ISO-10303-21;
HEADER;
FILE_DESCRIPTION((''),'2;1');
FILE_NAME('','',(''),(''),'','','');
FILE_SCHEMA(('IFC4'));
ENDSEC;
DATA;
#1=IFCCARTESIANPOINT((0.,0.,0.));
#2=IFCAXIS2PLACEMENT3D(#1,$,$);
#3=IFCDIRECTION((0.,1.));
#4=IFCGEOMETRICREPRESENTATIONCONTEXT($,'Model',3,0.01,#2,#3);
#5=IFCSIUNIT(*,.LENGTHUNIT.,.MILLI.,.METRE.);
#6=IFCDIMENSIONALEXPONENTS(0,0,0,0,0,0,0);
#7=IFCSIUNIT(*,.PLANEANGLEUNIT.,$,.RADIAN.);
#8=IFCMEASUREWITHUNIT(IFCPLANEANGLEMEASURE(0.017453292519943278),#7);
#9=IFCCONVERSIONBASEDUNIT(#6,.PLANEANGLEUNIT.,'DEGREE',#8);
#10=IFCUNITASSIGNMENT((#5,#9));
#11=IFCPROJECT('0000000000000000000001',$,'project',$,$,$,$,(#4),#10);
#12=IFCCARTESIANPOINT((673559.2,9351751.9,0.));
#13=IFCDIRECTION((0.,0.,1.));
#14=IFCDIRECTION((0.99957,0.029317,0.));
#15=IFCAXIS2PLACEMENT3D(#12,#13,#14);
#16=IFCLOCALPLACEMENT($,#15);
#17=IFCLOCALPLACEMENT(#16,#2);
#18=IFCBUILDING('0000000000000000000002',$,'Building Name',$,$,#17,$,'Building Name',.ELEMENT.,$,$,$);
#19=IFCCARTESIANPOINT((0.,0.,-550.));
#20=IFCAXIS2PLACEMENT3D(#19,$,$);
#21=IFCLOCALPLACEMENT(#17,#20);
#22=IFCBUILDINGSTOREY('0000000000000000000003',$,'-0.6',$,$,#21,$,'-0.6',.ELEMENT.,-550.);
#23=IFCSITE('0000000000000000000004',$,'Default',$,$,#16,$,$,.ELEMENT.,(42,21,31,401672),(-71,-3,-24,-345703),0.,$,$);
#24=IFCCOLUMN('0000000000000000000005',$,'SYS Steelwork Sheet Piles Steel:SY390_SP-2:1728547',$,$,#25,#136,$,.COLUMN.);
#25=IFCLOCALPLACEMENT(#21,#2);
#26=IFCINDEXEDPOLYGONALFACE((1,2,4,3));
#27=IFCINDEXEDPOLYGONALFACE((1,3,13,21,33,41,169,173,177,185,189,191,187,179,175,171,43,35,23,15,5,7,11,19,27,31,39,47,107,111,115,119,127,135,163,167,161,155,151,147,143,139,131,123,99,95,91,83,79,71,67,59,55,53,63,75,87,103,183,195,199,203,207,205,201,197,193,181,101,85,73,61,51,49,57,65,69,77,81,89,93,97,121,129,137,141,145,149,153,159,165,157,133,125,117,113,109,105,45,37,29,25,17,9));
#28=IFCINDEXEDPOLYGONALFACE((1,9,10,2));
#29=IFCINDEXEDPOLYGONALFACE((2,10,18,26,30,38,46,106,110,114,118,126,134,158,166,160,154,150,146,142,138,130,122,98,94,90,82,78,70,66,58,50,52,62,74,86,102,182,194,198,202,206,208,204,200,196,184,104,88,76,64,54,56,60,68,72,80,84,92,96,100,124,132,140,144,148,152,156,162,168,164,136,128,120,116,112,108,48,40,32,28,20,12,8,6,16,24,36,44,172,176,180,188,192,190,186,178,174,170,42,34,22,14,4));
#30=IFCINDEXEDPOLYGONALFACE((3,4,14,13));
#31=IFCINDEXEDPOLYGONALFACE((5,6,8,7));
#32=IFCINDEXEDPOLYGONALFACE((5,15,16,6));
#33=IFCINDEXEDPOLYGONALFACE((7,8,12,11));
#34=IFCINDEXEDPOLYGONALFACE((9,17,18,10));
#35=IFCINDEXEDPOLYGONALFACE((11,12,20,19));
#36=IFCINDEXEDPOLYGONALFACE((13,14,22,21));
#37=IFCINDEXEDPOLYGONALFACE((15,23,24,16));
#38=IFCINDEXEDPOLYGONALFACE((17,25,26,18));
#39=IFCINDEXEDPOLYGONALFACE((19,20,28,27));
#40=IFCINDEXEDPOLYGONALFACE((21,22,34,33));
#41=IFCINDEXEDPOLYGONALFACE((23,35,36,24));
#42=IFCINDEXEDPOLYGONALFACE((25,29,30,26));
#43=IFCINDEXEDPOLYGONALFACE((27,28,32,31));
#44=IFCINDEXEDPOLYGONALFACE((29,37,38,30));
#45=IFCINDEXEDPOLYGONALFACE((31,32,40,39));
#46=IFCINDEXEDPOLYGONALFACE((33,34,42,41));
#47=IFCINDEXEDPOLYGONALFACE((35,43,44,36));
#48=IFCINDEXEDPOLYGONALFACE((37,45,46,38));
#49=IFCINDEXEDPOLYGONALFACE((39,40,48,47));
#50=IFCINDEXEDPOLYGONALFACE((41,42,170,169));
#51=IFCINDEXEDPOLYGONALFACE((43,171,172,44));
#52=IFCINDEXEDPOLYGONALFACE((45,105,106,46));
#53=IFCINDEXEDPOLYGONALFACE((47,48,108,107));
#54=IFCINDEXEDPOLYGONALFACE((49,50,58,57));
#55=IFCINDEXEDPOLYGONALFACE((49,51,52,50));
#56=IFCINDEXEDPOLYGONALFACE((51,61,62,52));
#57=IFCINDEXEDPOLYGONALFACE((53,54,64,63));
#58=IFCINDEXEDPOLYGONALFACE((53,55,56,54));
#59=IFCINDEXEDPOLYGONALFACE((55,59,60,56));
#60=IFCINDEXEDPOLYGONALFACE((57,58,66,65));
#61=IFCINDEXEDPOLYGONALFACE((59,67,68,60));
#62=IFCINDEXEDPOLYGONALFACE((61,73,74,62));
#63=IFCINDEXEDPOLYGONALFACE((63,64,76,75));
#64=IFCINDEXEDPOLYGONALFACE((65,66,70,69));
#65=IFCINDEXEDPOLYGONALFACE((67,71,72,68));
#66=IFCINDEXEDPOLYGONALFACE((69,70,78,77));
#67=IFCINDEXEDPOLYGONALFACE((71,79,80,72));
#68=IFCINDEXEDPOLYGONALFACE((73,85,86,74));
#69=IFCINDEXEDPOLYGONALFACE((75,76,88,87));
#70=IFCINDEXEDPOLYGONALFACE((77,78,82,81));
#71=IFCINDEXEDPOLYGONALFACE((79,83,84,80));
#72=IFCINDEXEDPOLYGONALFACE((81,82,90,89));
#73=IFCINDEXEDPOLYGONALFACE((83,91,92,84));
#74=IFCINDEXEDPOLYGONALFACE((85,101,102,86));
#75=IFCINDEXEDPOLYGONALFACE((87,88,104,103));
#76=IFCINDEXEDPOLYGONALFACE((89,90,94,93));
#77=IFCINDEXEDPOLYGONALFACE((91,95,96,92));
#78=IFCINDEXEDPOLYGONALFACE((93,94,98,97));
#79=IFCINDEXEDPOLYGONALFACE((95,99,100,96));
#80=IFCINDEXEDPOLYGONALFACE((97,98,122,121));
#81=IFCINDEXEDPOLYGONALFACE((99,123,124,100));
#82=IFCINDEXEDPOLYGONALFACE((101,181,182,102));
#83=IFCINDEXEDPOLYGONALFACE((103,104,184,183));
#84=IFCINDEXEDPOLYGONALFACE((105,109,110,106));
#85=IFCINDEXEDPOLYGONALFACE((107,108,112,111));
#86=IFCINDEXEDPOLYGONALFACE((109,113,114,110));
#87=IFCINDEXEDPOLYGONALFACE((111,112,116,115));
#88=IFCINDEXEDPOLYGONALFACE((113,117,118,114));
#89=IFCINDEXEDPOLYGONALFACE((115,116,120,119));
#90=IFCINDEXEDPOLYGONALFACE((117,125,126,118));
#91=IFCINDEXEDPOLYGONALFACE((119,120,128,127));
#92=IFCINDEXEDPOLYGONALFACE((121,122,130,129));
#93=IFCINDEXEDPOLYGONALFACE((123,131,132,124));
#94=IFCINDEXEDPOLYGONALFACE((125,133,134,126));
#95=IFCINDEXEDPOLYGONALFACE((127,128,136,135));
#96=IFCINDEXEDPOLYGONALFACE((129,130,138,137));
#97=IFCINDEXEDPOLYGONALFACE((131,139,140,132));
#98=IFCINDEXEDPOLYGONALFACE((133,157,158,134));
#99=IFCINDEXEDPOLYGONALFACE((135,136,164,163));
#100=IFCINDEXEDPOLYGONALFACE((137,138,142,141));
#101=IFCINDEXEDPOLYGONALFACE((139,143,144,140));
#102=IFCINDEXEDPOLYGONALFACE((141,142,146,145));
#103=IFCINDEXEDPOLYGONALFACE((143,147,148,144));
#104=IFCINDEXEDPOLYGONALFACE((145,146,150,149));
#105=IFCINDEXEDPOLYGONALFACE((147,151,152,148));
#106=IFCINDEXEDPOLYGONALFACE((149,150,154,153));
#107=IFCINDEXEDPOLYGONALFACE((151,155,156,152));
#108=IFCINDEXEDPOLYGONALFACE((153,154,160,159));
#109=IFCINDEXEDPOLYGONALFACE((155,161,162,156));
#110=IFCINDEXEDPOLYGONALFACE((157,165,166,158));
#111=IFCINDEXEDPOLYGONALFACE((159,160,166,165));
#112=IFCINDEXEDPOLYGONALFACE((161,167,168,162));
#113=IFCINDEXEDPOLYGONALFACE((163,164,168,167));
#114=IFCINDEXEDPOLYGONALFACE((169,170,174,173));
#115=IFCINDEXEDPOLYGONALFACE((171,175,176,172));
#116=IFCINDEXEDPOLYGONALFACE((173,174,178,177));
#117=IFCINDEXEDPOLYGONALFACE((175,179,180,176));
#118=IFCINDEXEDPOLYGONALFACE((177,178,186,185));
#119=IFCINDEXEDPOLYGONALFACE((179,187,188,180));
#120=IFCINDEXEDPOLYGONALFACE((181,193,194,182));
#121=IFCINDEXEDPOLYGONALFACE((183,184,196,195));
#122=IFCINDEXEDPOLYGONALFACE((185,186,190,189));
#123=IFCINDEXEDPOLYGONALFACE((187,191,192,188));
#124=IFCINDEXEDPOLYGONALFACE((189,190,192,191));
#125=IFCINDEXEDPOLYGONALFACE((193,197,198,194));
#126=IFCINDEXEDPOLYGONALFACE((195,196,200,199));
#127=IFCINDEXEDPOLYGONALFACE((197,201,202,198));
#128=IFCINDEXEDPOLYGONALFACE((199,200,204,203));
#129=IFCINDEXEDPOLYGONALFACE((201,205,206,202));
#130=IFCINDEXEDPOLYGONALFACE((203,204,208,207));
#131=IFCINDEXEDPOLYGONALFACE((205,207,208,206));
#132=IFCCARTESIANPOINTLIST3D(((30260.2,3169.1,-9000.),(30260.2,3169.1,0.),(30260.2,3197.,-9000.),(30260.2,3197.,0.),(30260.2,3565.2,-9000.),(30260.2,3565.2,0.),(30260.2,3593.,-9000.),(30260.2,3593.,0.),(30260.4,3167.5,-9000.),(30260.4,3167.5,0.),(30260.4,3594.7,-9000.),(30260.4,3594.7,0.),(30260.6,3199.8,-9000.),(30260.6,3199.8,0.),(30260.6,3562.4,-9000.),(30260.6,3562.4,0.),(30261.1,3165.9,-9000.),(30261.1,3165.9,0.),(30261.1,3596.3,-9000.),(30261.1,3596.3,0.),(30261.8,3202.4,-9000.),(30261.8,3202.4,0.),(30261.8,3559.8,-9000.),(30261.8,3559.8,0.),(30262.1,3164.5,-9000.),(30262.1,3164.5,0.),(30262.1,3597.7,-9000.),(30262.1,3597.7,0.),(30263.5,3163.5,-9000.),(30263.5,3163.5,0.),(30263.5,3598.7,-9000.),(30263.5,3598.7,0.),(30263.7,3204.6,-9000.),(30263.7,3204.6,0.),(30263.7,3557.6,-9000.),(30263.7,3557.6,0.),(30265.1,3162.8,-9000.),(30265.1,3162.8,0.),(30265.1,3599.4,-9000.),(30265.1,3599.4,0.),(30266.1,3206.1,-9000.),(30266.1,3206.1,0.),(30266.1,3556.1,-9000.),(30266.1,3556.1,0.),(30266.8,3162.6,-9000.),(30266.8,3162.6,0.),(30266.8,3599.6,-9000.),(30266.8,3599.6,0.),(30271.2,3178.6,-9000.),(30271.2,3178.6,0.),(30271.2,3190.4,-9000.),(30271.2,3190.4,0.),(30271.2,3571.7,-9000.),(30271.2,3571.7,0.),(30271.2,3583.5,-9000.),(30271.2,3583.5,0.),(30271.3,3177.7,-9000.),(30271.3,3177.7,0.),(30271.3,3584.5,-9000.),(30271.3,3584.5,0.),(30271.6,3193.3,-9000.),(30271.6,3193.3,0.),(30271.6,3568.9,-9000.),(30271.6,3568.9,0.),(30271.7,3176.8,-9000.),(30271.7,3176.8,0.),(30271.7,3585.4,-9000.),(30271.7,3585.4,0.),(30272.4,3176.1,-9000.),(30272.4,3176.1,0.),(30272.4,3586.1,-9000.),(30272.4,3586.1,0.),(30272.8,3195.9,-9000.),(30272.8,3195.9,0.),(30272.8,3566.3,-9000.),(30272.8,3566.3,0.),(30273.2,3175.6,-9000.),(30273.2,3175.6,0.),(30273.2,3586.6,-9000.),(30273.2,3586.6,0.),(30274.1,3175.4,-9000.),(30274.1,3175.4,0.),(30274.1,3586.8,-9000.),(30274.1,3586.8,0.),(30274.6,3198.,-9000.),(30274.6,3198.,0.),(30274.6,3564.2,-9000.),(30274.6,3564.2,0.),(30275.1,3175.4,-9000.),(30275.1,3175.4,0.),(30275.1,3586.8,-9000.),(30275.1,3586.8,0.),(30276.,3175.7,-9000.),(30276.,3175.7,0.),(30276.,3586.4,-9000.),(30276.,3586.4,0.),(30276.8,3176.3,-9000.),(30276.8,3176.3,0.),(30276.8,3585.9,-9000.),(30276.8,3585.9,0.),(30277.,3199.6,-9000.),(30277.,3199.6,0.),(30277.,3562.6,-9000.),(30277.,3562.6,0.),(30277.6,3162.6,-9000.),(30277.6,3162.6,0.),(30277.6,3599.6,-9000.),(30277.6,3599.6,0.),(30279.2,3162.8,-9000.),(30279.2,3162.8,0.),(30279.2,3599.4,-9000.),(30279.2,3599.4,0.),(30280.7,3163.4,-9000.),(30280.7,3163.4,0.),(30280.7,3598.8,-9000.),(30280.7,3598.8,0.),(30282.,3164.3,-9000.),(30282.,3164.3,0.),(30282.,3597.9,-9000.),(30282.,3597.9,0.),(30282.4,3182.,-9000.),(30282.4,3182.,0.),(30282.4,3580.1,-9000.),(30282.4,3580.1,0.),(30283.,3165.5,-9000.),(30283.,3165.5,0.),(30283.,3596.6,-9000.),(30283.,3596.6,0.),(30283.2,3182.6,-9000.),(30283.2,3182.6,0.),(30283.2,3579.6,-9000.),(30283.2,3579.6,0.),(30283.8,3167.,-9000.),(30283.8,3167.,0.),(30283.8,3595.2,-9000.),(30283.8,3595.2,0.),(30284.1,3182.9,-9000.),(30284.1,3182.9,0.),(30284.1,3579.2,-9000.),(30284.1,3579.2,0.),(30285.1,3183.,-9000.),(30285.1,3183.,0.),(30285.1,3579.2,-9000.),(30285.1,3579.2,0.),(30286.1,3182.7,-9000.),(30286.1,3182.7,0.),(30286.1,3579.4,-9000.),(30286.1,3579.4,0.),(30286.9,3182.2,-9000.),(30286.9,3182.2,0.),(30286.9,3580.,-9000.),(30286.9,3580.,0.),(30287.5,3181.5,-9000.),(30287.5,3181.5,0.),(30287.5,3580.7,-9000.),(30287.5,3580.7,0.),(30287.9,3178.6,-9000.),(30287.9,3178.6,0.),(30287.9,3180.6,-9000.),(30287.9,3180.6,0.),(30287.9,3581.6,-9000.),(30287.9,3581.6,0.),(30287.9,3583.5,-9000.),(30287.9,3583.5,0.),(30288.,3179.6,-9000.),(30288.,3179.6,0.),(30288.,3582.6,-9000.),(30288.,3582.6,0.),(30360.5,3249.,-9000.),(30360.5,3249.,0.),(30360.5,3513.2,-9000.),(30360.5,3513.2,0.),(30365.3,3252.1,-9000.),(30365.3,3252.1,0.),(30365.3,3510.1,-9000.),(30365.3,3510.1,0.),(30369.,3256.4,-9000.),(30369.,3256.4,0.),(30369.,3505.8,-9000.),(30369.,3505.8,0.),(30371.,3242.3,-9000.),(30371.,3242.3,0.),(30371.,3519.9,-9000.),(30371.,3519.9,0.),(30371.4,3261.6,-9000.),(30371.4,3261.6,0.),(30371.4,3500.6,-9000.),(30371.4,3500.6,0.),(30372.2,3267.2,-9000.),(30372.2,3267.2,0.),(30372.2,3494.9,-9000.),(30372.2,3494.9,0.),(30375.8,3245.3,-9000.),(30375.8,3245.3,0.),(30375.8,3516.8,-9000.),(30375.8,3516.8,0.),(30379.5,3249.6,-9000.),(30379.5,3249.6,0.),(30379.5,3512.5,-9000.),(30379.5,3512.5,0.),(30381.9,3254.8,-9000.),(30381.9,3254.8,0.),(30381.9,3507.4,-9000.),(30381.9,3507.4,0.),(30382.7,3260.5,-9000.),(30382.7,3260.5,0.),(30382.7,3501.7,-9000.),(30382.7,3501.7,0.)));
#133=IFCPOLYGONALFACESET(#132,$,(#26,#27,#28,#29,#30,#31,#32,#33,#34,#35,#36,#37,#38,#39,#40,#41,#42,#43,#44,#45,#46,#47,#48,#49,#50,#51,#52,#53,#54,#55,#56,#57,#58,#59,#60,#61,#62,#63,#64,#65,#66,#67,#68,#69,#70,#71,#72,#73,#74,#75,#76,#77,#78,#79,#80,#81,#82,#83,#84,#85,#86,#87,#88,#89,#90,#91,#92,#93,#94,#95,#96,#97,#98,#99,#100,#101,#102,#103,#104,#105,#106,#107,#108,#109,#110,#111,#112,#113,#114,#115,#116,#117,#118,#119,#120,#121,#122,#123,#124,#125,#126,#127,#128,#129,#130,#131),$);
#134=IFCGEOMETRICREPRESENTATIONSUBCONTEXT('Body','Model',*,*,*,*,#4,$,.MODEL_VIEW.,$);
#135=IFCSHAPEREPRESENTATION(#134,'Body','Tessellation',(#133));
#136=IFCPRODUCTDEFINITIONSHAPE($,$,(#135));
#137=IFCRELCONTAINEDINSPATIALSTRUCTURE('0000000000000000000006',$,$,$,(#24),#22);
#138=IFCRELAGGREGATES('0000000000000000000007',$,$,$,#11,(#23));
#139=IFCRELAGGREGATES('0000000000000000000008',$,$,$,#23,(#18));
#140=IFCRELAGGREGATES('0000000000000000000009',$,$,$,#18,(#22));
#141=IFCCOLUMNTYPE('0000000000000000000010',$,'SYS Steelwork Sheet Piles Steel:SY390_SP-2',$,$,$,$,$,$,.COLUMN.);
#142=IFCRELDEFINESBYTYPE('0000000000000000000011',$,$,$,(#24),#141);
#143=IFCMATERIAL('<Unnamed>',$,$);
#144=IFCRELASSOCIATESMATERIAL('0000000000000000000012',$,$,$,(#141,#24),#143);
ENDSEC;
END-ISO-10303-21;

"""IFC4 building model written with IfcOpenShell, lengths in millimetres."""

from ifc_helpers import new_model, entity, si_unit, converted_unit, direction, frame, origin, place, context, subcontext, project, spatial, line, arc, indexed_curve, outline, extrude, source, transform, mapped, material, type_object, type_shapes, element, save


model = new_model("IFC4")

# Units and contexts
model_context = context("Model", 3, precision=0.01, world=origin(), true_north=direction((0.0, 1.0)))
body_context = subcontext(model_context, "Body", "Model", "MODEL_VIEW")
ifc_project = project(units=[si_unit("LENGTHUNIT", "METRE", prefix="MILLI"), converted_unit("PLANEANGLEUNIT", "DEGREE", entity("IfcPlaneAngleMeasure", 0.017453292519943278), si_unit("PLANEANGLEUNIT", "RADIAN"), dimensions=[0, 0, 0, 0, 0, 0, 0])], contexts=[model_context])

# Site, building, storey
site_placement = place(None, frame((673559.2, 9351751.9, 0.0), z_axis=(0.0, 0.0, 1.0), x_axis=(0.99957, 0.029317, 0.0)))
site = spatial("IfcSite", under=ifc_project, at=site_placement, Name="Default", CompositionType="ELEMENT", RefLatitude=(42, 21, 31, 401672), RefLongitude=(-71, -3, -24, -345703), RefElevation=0.0)
building_placement = place(site_placement, origin())
building = spatial("IfcBuilding", under=site, at=building_placement, Name="Building Name", LongName="Building Name", CompositionType="ELEMENT")
storey_placement = place(building_placement, frame((0.0, 0.0, -550.0)))
storey = spatial("IfcBuildingStorey", under=building, at=storey_placement, Name="-0.6", LongName="-0.6", CompositionType="ELEMENT", Elevation=-550.0)

# Column
ifc_material_1 = material(Name="<Unnamed>")
column_type = type_object("IfcColumnType", Name="SYS Steelwork Sheet Piles Steel:SY390_SP-2", PredefinedType="COLUMN", material=ifc_material_1)
shared_shape_1 = source(origin(), body_context, "Body", "SweptSolid", [
    extrude(outline(indexed_curve([(-120.6, 84.7), (-131.4, 81.6), (-138.8, 73.0), (-181.5, -20.9), (-185.2, -25.2), (-190.6, -26.8), (-202.5, -26.8), (-205.5, -24.8), (-204.8, -21.2), (-199.1, -15.5), (-198.6, -11.5), (-202.5, -10.1), (-214.1, -14.2), (-217.3, -16.6), (-218.5, -20.4), (-218.5, -31.2), (-216.6, -35.8), (-211.9, -37.8), (-184.1, -37.8), (-178.7, -36.2), (-175.0, -31.9), (-132.1, 62.5), (-124.7, 71.1), (-113.9, 74.2), (113.9, 74.2), (124.7, 71.1), (132.1, 62.5), (175.0, -31.9), (178.7, -36.2), (184.1, -37.8), (211.9, -37.8), (216.6, -35.8), (218.5, -31.2), (218.5, -20.4), (217.3, -16.6), (214.1, -14.2), (202.5, -10.1), (198.6, -11.5), (199.1, -15.5), (204.8, -21.2), (205.5, -24.8), (202.5, -26.8), (190.6, -26.8), (185.2, -25.2), (181.5, -20.9), (138.8, 73.0), (131.4, 81.6), (120.6, 84.7)], segments=[arc(1, 2, 3), line(3, 4), arc(4, 5, 6), line(6, 7), arc(7, 8, 9), line(9, 10), arc(10, 11, 12), line(12, 13), arc(13, 14, 15), line(15, 16), arc(16, 17, 18), line(18, 19), arc(19, 20, 21), line(21, 22), arc(22, 23, 24), line(24, 25), arc(25, 26, 27), line(27, 28), arc(28, 29, 30), line(30, 31), arc(31, 32, 33), line(33, 34), arc(34, 35, 36), line(36, 37), arc(37, 38, 39), line(39, 40), arc(40, 41, 42), line(42, 43), arc(43, 44, 45), line(45, 46), arc(46, 47, 48), line(48, 1)], self_intersect=False)), frame((0.0, 15.3, -9550.0)), (0.0, 0.0, 1.0), 9000.0),
])
type_shapes(column_type, [shared_shape_1])
for number, where, z_axis, x_axis, name in (
    (1, (30282.7, 3381.1, 550.0), (0.0, 0.0, 1.0), (0.0, -1.0, 0.0), "SYS Steelwork Sheet Piles Steel:SY390_SP-2:1728547"),
):
    element("IfcColumn", number, at=place(storey_placement, frame(where, z_axis=z_axis, x_axis=x_axis)), inside=storey, type_object=column_type, material=ifc_material_1, Name=name, PredefinedType="COLUMN", context=body_context, shape_type="MappedRepresentation", body=[
        mapped(shared_shape_1, transform((0.0, 0.0, 0.0), scale=1.0)),
    ])

save(model, "model.ifc")
